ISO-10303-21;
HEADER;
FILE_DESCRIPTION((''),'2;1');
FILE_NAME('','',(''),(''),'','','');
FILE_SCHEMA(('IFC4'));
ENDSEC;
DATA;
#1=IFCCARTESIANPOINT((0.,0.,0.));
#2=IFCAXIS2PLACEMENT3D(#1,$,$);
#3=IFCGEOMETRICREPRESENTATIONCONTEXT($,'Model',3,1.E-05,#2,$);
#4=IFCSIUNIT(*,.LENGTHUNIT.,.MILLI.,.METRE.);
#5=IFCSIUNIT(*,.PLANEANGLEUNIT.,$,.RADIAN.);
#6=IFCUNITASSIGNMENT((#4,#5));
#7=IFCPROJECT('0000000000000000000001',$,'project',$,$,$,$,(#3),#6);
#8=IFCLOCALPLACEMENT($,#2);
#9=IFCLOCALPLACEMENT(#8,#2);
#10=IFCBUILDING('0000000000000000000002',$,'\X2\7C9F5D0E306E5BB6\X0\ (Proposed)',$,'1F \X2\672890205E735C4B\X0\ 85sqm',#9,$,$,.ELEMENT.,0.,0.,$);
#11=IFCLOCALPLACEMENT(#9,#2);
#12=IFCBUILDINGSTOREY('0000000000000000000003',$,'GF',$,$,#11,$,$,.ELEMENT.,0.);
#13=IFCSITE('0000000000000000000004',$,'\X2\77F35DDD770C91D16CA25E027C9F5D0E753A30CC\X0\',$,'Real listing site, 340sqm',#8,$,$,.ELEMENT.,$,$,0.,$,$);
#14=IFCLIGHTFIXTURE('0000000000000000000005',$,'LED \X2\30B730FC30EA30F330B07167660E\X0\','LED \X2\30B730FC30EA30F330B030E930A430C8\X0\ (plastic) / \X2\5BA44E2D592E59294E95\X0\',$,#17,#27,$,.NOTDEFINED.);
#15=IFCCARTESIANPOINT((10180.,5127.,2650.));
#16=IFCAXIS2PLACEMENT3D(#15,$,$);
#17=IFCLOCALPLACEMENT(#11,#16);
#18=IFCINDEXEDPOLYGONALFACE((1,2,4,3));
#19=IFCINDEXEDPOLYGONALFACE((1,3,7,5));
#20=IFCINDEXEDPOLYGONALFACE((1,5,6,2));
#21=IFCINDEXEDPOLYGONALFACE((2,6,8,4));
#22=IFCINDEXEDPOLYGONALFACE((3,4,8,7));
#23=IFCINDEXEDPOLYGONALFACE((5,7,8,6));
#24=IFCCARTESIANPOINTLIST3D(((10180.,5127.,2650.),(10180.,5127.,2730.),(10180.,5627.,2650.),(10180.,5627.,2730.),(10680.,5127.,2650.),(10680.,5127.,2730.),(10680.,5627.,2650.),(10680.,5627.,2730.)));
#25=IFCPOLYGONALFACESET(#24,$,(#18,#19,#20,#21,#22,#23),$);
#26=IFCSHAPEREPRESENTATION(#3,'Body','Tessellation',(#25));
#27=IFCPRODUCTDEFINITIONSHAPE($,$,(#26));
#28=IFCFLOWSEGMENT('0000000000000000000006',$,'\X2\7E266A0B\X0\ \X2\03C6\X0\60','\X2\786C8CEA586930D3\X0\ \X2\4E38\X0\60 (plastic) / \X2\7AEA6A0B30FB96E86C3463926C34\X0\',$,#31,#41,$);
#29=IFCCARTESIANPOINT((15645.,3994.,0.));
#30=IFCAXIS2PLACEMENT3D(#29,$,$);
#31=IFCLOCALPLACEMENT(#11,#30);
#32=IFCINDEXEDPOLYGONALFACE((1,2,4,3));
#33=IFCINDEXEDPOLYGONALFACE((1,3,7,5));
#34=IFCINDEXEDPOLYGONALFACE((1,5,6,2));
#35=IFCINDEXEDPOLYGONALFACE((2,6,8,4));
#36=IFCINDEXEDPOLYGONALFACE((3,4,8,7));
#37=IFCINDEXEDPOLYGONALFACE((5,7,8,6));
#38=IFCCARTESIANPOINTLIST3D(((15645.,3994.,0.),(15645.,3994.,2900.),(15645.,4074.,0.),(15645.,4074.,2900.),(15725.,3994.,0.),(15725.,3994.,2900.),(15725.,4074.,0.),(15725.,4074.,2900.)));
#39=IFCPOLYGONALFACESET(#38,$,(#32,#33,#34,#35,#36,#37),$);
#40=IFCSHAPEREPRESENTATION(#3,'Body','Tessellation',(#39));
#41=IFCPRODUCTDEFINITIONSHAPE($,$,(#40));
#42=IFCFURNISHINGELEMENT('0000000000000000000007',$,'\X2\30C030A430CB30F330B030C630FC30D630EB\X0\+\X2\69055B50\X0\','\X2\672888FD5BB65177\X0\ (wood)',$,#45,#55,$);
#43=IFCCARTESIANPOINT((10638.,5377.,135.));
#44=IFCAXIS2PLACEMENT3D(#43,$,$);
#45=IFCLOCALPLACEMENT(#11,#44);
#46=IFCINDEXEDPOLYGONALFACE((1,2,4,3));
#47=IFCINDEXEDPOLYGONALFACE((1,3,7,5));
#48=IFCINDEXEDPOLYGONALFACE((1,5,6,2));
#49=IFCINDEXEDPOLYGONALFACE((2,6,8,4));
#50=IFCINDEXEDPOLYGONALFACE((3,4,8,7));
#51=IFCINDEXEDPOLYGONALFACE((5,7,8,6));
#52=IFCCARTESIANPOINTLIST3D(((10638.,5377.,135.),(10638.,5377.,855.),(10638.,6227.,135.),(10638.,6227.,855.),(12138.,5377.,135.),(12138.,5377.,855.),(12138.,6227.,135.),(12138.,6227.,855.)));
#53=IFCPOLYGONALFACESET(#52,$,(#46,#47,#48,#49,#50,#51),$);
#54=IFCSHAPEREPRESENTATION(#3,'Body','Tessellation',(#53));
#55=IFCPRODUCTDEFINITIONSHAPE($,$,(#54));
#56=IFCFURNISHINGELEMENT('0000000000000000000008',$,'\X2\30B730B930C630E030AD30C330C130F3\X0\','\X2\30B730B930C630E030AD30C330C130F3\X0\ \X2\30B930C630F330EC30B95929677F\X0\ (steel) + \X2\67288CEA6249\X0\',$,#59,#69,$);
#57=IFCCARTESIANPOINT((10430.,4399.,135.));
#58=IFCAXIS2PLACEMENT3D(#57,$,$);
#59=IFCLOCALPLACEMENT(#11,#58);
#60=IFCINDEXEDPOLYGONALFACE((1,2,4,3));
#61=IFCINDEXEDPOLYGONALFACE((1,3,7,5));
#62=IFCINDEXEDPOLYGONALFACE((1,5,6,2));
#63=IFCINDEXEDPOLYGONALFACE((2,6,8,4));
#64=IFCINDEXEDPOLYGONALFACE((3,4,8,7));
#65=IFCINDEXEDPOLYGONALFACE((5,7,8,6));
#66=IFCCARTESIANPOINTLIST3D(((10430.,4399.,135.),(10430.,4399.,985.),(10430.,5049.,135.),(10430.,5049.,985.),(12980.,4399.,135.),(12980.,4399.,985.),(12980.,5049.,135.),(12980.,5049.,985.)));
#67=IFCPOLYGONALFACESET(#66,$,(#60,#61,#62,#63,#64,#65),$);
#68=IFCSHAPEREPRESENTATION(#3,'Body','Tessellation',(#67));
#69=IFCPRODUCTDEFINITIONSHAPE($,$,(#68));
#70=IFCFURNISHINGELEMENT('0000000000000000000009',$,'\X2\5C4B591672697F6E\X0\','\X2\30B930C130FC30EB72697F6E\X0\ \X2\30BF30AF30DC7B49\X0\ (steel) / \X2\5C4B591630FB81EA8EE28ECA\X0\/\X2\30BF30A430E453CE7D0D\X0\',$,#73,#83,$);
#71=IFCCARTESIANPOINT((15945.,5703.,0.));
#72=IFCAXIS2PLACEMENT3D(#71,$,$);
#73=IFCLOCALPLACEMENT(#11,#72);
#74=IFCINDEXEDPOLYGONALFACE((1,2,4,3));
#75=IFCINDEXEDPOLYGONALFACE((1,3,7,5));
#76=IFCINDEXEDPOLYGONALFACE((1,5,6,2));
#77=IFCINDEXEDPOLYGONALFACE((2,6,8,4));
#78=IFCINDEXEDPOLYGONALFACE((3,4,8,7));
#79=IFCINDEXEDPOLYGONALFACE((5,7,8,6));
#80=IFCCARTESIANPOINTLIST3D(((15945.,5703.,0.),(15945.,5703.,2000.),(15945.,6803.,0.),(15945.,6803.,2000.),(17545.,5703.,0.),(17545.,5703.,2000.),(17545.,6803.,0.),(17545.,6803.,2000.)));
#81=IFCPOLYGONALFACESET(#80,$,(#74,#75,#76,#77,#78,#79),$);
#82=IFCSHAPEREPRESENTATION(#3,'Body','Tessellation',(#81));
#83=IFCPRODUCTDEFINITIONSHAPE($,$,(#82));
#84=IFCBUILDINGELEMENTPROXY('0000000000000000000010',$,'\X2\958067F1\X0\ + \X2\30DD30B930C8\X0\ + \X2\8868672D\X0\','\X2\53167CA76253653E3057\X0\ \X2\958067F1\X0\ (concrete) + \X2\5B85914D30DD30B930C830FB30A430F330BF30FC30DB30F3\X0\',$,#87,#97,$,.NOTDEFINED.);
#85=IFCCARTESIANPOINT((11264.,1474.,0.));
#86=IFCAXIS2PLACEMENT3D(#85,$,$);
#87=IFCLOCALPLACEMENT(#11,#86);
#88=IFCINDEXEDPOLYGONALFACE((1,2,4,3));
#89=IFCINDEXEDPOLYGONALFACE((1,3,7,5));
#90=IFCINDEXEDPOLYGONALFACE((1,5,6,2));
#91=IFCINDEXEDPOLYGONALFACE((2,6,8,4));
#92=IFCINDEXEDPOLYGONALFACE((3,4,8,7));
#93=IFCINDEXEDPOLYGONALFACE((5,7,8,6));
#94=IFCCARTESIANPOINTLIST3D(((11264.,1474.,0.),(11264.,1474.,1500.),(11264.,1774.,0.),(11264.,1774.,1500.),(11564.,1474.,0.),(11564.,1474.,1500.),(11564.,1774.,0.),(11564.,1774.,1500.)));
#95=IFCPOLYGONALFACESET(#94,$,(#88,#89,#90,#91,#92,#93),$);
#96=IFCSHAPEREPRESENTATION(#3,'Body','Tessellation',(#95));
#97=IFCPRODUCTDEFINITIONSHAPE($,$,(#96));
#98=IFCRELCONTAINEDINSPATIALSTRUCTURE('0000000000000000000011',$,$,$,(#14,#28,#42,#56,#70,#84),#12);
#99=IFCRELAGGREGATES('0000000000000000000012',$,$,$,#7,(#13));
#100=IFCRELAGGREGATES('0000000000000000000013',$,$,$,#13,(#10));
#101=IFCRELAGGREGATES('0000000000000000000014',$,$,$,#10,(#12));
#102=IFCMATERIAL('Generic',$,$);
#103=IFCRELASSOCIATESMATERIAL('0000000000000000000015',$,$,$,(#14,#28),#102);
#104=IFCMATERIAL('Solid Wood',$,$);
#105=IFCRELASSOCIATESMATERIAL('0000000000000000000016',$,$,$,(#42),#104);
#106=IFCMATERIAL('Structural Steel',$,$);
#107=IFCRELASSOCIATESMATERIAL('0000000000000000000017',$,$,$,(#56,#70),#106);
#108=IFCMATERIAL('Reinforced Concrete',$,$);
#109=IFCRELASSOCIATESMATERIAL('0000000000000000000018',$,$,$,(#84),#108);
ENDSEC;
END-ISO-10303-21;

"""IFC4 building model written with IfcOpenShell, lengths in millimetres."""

from ifc_helpers import new_model, si_unit, frame, frame_2d, origin, place, context, project, spatial, rectangle, extrude, material, element, save


model = new_model("IFC4")

# Units and contexts
model_context = context("Model", 3, precision=1e-05, world=origin())
ifc_project = project(units=[si_unit("LENGTHUNIT", "METRE", prefix="MILLI"), si_unit("PLANEANGLEUNIT", "RADIAN")], contexts=[model_context])

# Site, building, storey
site_placement = place(None, origin())
site = spatial("IfcSite", under=ifc_project, at=site_placement, Name="石川県金沢市粟崎町ヌ", ObjectType="Real listing site, 340sqm", CompositionType="ELEMENT", RefElevation=0.0)
building_placement = place(site_placement, origin())
building = spatial("IfcBuilding", under=site, at=building_placement, Name="粟崎の家 (Proposed)", ObjectType="1F 木造平屋 85sqm", CompositionType="ELEMENT", ElevationOfRefHeight=0.0, ElevationOfTerrain=0.0)
storey_placement = place(building_placement, origin())
storey = spatial("IfcBuildingStorey", under=building, at=storey_placement, Name="GF", CompositionType="ELEMENT", Elevation=0.0)

# Shared definitions
ifc_material_1 = material(Name="Solid Wood")

# Shared definitions
ifc_material_2 = material(Name="Structural Steel")

# Shared definitions
ifc_material_3 = material(Name="Reinforced Concrete")

# Shared definitions
ifc_material_4 = material(Name="Generic")

# Light fixture
light_fixture_placement = place(storey_placement, frame((10180.0, 5127.0, 2650.0)))
element("IfcLightFixture", 1, at=light_fixture_placement, inside=storey, material=ifc_material_4, Name="LED シーリング照明", Description="LED シーリングライト (plastic) / 室中央天井", PredefinedType="NOTDEFINED", context=model_context, shape_type="SweptSolid", body=[
    extrude(rectangle(XDim=500.0, YDim=500.0, at=frame_2d((250.0, 250.0))), frame((10180.0, 5127.0, 2650.0)), (0.0, 0.0, 1.0), 80.0),
])

# Flow segment
flow_segment_placement = place(storey_placement, frame((15645.0, 3994.0, 0.0)))
element("IfcFlowSegment", 2, at=flow_segment_placement, inside=storey, material=ifc_material_4, Name="縦樋 φ60", Description="硬質塩ビ 丸60 (plastic) / 竪樋・雨水排水", context=model_context, shape_type="SweptSolid", body=[
    extrude(rectangle(XDim=80.0, YDim=80.0, at=frame_2d((40.0, 40.0))), frame((15645.0, 3994.0, 0.0)), (0.0, 0.0, 1.0), 2900.0),
])

# Furnishing elements
furnishing_1_placement = place(storey_placement, frame((10638.0, 5377.0, 135.0)))
element("IfcFurnishingElement", 3, at=furnishing_1_placement, inside=storey, material=ifc_material_1, Name="ダイニングテーブル+椅子", Description="木製家具 (wood)", context=model_context, shape_type="SweptSolid", body=[
    extrude(rectangle(XDim=1500.0, YDim=850.0, at=frame_2d((750.0, 425.0))), frame((10638.0, 5377.0, 135.0)), (0.0, 0.0, 1.0), 720.0),
])
furnishing_2_placement = place(storey_placement, frame((10430.0, 4399.0, 135.0)))
element("IfcFurnishingElement", 4, at=furnishing_2_placement, inside=storey, material=ifc_material_2, Name="システムキッチン", Description="システムキッチン ステンレス天板 (steel) + 木質扉", context=model_context, shape_type="SweptSolid", body=[
    extrude(rectangle(XDim=2550.0, YDim=650.0, at=frame_2d((1275.0, 325.0))), frame((10430.0, 4399.0, 135.0)), (0.0, 0.0, 1.0), 850.0),
])
furnishing_3_placement = place(storey_placement, frame((15945.0, 5703.0, 0.0)))
element("IfcFurnishingElement", 5, at=furnishing_3_placement, inside=storey, material=ifc_material_2, Name="屋外物置", Description="スチール物置 タクボ等 (steel) / 屋外・自転車/タイヤ収納", context=model_context, shape_type="SweptSolid", body=[
    extrude(rectangle(XDim=1600.0, YDim=1100.0, at=frame_2d((800.0, 550.0))), frame((15945.0, 5703.0, 0.0)), (0.0, 0.0, 1.0), 2000.0),
])

# Building element proxy
proxy_placement = place(storey_placement, frame((11264.0, 1474.0, 0.0)))
element("IfcBuildingElementProxy", 6, at=proxy_placement, inside=storey, material=ifc_material_3, Name="門柱 + ポスト + 表札", Description="化粧打放し 門柱 (concrete) + 宅配ポスト・インターホン", PredefinedType="NOTDEFINED", context=model_context, shape_type="SweptSolid", body=[
    extrude(rectangle(XDim=300.0, YDim=300.0, at=frame_2d((150.0, 150.0))), frame((11264.0, 1474.0, 0.0)), (0.0, 0.0, 1.0), 1500.0),
])

save(model, "model.ifc")
